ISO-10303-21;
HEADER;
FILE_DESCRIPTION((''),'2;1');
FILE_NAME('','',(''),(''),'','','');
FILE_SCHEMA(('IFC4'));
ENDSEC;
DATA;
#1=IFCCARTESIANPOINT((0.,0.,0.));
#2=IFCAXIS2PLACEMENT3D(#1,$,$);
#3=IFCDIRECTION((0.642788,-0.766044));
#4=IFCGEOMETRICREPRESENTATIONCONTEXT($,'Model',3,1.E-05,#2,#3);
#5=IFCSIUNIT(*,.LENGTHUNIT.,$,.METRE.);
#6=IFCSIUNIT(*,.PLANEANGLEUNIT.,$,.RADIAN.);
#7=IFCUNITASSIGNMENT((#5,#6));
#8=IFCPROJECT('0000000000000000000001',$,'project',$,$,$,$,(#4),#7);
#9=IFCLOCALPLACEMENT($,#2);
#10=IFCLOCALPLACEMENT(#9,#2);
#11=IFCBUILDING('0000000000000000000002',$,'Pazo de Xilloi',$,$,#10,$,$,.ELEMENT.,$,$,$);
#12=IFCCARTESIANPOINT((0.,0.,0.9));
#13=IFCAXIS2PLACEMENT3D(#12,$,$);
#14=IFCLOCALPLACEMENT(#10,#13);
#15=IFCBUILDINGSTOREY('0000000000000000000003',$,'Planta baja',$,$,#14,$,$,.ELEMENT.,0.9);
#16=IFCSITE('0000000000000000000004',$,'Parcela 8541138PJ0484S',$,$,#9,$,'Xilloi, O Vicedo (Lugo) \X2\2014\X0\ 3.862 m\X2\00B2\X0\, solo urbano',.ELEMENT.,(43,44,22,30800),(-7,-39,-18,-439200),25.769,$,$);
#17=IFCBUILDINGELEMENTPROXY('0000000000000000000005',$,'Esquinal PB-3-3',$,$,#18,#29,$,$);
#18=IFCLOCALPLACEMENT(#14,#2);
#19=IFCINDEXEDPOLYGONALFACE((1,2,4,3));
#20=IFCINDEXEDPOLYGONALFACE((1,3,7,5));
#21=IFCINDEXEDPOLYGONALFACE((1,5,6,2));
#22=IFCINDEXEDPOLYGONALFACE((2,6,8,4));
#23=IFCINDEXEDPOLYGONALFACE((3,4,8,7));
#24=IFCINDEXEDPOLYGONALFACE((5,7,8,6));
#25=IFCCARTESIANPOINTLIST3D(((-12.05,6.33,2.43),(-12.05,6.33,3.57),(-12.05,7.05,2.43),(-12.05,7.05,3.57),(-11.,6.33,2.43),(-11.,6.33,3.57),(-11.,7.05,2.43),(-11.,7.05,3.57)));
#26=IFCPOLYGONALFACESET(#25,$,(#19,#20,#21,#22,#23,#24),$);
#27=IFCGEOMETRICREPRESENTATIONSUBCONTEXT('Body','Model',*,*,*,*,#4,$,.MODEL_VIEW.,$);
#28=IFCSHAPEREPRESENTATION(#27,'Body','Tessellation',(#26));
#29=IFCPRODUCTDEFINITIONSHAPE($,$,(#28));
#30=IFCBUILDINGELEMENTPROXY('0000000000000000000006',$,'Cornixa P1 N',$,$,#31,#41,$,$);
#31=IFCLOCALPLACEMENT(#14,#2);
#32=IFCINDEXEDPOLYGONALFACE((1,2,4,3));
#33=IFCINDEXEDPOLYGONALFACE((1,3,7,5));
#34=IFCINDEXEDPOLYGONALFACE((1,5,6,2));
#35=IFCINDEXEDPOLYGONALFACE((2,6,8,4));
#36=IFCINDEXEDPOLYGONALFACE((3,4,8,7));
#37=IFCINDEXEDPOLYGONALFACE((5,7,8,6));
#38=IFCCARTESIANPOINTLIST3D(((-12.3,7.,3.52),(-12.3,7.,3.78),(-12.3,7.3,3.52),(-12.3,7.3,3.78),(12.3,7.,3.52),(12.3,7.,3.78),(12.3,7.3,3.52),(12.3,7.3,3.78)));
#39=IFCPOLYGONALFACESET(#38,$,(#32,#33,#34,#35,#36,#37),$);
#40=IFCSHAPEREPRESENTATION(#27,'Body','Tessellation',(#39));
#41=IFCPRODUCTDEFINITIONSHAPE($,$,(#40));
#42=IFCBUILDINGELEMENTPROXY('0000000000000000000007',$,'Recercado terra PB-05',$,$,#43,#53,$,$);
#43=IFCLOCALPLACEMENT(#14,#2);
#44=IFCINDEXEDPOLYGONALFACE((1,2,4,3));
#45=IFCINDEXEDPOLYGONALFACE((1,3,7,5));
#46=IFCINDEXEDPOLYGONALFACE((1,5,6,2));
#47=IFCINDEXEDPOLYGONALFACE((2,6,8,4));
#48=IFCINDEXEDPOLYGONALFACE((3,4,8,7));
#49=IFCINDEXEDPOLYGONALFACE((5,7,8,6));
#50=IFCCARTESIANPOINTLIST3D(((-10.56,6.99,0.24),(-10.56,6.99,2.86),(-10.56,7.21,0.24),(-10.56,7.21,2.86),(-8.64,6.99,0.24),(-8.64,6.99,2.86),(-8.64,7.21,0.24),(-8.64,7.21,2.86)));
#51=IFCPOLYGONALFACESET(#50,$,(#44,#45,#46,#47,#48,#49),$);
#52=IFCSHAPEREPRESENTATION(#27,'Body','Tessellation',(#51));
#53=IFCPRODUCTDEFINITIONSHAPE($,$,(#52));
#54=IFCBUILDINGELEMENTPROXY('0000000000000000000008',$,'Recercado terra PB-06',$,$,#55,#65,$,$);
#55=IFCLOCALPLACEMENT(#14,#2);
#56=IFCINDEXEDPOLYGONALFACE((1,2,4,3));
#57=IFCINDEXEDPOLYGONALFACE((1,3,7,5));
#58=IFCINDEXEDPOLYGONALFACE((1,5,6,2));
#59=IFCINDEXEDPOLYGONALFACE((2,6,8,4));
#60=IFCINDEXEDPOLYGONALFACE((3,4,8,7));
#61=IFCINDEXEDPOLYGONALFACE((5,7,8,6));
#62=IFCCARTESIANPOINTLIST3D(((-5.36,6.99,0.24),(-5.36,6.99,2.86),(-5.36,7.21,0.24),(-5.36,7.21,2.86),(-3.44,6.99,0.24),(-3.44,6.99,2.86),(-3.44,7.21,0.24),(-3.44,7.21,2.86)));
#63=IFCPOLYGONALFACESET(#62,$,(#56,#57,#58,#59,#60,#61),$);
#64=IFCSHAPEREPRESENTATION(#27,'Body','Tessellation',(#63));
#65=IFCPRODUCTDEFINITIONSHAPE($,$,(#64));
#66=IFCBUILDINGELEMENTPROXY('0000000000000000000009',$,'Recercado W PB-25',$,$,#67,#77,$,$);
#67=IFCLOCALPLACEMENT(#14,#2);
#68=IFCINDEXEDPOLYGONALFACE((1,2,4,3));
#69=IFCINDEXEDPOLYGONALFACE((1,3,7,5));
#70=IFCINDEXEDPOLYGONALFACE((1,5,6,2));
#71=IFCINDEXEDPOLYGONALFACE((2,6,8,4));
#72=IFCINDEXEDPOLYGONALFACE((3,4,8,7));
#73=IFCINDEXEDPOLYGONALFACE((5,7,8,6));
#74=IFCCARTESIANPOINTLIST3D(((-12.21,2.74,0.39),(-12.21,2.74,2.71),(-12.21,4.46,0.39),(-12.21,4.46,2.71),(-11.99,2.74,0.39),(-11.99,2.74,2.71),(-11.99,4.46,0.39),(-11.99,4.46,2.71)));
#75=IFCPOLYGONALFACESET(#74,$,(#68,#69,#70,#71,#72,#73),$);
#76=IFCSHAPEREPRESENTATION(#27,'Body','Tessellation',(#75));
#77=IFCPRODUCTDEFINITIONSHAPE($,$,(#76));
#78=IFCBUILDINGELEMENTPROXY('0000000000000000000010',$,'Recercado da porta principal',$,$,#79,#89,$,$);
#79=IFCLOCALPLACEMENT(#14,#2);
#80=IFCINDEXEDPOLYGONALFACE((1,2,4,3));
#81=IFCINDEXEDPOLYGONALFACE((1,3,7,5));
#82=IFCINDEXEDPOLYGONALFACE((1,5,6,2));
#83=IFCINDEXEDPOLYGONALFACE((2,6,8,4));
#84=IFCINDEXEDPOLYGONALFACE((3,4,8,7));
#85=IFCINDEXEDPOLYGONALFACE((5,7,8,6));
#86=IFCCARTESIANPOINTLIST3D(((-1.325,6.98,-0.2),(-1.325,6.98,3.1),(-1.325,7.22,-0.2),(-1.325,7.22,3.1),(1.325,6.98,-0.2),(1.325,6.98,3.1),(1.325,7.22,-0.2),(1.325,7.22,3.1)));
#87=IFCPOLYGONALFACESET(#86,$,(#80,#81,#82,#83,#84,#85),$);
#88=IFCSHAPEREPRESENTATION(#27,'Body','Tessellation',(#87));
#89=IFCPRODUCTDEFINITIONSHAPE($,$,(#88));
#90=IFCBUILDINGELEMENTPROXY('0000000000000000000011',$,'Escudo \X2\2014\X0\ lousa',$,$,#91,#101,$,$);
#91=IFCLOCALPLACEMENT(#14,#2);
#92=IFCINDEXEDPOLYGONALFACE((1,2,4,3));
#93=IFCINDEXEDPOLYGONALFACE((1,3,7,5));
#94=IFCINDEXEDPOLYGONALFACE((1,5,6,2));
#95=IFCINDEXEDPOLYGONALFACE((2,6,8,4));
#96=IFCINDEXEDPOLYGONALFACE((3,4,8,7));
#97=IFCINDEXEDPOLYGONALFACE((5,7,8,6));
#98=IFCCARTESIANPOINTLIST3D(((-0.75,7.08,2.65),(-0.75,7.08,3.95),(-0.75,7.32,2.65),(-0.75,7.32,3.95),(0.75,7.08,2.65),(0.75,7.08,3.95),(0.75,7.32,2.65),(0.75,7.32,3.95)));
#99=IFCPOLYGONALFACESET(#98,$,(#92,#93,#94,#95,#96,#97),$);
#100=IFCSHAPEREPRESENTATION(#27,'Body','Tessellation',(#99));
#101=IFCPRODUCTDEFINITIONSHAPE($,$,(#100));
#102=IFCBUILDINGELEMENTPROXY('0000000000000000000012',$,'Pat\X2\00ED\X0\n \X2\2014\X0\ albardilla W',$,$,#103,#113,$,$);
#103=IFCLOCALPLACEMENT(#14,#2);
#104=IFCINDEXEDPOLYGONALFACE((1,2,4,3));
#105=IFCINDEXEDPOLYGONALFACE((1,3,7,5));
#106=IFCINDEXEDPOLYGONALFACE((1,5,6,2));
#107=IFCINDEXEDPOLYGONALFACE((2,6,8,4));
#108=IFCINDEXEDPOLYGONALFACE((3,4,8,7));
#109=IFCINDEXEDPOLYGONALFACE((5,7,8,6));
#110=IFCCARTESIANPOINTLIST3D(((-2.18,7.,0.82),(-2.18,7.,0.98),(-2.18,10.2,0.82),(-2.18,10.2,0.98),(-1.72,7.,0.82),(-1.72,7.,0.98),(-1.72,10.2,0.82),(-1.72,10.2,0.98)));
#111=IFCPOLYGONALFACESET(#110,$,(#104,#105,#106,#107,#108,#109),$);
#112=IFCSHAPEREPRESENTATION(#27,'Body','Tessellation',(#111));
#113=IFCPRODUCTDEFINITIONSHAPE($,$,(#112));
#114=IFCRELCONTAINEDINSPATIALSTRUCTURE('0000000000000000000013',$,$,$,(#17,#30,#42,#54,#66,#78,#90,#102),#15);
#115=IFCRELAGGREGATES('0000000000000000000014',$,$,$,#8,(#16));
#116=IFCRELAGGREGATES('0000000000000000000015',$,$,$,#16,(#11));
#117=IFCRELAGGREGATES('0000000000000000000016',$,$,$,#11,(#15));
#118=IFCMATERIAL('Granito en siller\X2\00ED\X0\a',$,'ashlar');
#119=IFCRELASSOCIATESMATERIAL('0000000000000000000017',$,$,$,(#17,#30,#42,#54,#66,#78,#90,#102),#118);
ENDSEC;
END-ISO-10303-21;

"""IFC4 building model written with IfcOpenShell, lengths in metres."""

from ifc_helpers import new_model, si_unit, direction, frame, origin, origin_2d, place, context, subcontext, project, spatial, rectangle, extrude, material, element, save


model = new_model("IFC4")

# Units and contexts
model_context = context("Model", 3, precision=1e-05, world=origin(), true_north=direction((0.642788, -0.766044)))
body_context = subcontext(model_context, "Body", "Model", "MODEL_VIEW")
ifc_project = project(units=[si_unit("LENGTHUNIT", "METRE"), si_unit("PLANEANGLEUNIT", "RADIAN")], contexts=[model_context])

# Site, building, storey
site_placement = place(None, origin())
site = spatial("IfcSite", under=ifc_project, at=site_placement, Name="Parcela 8541138PJ0484S", LongName="Xilloi, O Vicedo (Lugo) — 3.862 m², solo urbano", CompositionType="ELEMENT", RefLatitude=(43, 44, 22, 30800), RefLongitude=(-7, -39, -18, -439200), RefElevation=25.769)
building_placement = place(site_placement, origin())
building = spatial("IfcBuilding", under=site, at=building_placement, Name="Pazo de Xilloi", CompositionType="ELEMENT")
storey_placement = place(building_placement, frame((0.0, 0.0, 0.9)))
storey = spatial("IfcBuildingStorey", under=building, at=storey_placement, Name="Planta baja", CompositionType="ELEMENT", Elevation=0.9)

# Building element proxies
ifc_material_1 = material(Name="Granito en sillería", Category="ashlar")
proxy_1_placement = place(storey_placement, frame((-11.525, 6.69, 3.0)))
element("IfcBuildingElementProxy", 1, at=proxy_1_placement, inside=storey, material=ifc_material_1, Name="Esquinal PB-3-3", context=body_context, shape_type="SweptSolid", body=[
    extrude(rectangle(XDim=1.05, YDim=0.72, at=origin_2d()), frame((0.0, 0.0, -0.57)), (0.0, 0.0, 1.0), 1.14),
])
proxy_2_placement = place(storey_placement, frame((0.0, 7.15, 3.65)))
element("IfcBuildingElementProxy", 2, at=proxy_2_placement, inside=storey, material=ifc_material_1, Name="Cornixa P1 N", context=body_context, shape_type="SweptSolid", body=[
    extrude(rectangle(XDim=24.6, YDim=0.3, at=origin_2d()), frame((0.0, 0.0, -0.13)), (0.0, 0.0, 1.0), 0.26),
])
for number, where, name in (
    (3, (-9.6, 7.1, 1.55), "Recercado terra PB-05"),
    (4, (-4.4, 7.1, 1.55), "Recercado terra PB-06"),
):
    element("IfcBuildingElementProxy", number, at=place(storey_placement, frame(where)), inside=storey, material=ifc_material_1, Name=name, context=body_context, shape_type="SweptSolid", body=[
        extrude(rectangle(XDim=1.92, YDim=0.22, at=origin_2d()), frame((0.0, 0.0, -1.31)), (0.0, 0.0, 1.0), 2.62),
    ])
proxy_3_placement = place(storey_placement, frame((-12.1, 3.6, 1.55)))
element("IfcBuildingElementProxy", 5, at=proxy_3_placement, inside=storey, material=ifc_material_1, Name="Recercado W PB-25", context=body_context, shape_type="SweptSolid", body=[
    extrude(rectangle(XDim=0.22, YDim=1.72, at=origin_2d()), frame((0.0, 0.0, -1.16)), (0.0, 0.0, 1.0), 2.32),
])
proxy_4_placement = place(storey_placement, frame((0.0, 7.1, 1.45)))
element("IfcBuildingElementProxy", 6, at=proxy_4_placement, inside=storey, material=ifc_material_1, Name="Recercado da porta principal", context=body_context, shape_type="SweptSolid", body=[
    extrude(rectangle(XDim=2.65, YDim=0.24, at=origin_2d()), frame((0.0, 0.0, -1.65)), (0.0, 0.0, 1.0), 3.3),
])
proxy_5_placement = place(storey_placement, frame((0.0, 7.2, 3.3)))
element("IfcBuildingElementProxy", 7, at=proxy_5_placement, inside=storey, material=ifc_material_1, Name="Escudo — lousa", context=body_context, shape_type="SweptSolid", body=[
    extrude(rectangle(XDim=1.5, YDim=0.24, at=origin_2d()), frame((0.0, 0.0, -0.65)), (0.0, 0.0, 1.0), 1.3),
])
proxy_6_placement = place(storey_placement, frame((-1.95, 8.6, 0.9)))
element("IfcBuildingElementProxy", 8, at=proxy_6_placement, inside=storey, material=ifc_material_1, Name="Patín — albardilla W", context=body_context, shape_type="SweptSolid", body=[
    extrude(rectangle(XDim=0.46, YDim=3.2, at=origin_2d()), frame((0.0, 0.0, -0.08)), (0.0, 0.0, 1.0), 0.16),
])

save(model, "model.ifc")
